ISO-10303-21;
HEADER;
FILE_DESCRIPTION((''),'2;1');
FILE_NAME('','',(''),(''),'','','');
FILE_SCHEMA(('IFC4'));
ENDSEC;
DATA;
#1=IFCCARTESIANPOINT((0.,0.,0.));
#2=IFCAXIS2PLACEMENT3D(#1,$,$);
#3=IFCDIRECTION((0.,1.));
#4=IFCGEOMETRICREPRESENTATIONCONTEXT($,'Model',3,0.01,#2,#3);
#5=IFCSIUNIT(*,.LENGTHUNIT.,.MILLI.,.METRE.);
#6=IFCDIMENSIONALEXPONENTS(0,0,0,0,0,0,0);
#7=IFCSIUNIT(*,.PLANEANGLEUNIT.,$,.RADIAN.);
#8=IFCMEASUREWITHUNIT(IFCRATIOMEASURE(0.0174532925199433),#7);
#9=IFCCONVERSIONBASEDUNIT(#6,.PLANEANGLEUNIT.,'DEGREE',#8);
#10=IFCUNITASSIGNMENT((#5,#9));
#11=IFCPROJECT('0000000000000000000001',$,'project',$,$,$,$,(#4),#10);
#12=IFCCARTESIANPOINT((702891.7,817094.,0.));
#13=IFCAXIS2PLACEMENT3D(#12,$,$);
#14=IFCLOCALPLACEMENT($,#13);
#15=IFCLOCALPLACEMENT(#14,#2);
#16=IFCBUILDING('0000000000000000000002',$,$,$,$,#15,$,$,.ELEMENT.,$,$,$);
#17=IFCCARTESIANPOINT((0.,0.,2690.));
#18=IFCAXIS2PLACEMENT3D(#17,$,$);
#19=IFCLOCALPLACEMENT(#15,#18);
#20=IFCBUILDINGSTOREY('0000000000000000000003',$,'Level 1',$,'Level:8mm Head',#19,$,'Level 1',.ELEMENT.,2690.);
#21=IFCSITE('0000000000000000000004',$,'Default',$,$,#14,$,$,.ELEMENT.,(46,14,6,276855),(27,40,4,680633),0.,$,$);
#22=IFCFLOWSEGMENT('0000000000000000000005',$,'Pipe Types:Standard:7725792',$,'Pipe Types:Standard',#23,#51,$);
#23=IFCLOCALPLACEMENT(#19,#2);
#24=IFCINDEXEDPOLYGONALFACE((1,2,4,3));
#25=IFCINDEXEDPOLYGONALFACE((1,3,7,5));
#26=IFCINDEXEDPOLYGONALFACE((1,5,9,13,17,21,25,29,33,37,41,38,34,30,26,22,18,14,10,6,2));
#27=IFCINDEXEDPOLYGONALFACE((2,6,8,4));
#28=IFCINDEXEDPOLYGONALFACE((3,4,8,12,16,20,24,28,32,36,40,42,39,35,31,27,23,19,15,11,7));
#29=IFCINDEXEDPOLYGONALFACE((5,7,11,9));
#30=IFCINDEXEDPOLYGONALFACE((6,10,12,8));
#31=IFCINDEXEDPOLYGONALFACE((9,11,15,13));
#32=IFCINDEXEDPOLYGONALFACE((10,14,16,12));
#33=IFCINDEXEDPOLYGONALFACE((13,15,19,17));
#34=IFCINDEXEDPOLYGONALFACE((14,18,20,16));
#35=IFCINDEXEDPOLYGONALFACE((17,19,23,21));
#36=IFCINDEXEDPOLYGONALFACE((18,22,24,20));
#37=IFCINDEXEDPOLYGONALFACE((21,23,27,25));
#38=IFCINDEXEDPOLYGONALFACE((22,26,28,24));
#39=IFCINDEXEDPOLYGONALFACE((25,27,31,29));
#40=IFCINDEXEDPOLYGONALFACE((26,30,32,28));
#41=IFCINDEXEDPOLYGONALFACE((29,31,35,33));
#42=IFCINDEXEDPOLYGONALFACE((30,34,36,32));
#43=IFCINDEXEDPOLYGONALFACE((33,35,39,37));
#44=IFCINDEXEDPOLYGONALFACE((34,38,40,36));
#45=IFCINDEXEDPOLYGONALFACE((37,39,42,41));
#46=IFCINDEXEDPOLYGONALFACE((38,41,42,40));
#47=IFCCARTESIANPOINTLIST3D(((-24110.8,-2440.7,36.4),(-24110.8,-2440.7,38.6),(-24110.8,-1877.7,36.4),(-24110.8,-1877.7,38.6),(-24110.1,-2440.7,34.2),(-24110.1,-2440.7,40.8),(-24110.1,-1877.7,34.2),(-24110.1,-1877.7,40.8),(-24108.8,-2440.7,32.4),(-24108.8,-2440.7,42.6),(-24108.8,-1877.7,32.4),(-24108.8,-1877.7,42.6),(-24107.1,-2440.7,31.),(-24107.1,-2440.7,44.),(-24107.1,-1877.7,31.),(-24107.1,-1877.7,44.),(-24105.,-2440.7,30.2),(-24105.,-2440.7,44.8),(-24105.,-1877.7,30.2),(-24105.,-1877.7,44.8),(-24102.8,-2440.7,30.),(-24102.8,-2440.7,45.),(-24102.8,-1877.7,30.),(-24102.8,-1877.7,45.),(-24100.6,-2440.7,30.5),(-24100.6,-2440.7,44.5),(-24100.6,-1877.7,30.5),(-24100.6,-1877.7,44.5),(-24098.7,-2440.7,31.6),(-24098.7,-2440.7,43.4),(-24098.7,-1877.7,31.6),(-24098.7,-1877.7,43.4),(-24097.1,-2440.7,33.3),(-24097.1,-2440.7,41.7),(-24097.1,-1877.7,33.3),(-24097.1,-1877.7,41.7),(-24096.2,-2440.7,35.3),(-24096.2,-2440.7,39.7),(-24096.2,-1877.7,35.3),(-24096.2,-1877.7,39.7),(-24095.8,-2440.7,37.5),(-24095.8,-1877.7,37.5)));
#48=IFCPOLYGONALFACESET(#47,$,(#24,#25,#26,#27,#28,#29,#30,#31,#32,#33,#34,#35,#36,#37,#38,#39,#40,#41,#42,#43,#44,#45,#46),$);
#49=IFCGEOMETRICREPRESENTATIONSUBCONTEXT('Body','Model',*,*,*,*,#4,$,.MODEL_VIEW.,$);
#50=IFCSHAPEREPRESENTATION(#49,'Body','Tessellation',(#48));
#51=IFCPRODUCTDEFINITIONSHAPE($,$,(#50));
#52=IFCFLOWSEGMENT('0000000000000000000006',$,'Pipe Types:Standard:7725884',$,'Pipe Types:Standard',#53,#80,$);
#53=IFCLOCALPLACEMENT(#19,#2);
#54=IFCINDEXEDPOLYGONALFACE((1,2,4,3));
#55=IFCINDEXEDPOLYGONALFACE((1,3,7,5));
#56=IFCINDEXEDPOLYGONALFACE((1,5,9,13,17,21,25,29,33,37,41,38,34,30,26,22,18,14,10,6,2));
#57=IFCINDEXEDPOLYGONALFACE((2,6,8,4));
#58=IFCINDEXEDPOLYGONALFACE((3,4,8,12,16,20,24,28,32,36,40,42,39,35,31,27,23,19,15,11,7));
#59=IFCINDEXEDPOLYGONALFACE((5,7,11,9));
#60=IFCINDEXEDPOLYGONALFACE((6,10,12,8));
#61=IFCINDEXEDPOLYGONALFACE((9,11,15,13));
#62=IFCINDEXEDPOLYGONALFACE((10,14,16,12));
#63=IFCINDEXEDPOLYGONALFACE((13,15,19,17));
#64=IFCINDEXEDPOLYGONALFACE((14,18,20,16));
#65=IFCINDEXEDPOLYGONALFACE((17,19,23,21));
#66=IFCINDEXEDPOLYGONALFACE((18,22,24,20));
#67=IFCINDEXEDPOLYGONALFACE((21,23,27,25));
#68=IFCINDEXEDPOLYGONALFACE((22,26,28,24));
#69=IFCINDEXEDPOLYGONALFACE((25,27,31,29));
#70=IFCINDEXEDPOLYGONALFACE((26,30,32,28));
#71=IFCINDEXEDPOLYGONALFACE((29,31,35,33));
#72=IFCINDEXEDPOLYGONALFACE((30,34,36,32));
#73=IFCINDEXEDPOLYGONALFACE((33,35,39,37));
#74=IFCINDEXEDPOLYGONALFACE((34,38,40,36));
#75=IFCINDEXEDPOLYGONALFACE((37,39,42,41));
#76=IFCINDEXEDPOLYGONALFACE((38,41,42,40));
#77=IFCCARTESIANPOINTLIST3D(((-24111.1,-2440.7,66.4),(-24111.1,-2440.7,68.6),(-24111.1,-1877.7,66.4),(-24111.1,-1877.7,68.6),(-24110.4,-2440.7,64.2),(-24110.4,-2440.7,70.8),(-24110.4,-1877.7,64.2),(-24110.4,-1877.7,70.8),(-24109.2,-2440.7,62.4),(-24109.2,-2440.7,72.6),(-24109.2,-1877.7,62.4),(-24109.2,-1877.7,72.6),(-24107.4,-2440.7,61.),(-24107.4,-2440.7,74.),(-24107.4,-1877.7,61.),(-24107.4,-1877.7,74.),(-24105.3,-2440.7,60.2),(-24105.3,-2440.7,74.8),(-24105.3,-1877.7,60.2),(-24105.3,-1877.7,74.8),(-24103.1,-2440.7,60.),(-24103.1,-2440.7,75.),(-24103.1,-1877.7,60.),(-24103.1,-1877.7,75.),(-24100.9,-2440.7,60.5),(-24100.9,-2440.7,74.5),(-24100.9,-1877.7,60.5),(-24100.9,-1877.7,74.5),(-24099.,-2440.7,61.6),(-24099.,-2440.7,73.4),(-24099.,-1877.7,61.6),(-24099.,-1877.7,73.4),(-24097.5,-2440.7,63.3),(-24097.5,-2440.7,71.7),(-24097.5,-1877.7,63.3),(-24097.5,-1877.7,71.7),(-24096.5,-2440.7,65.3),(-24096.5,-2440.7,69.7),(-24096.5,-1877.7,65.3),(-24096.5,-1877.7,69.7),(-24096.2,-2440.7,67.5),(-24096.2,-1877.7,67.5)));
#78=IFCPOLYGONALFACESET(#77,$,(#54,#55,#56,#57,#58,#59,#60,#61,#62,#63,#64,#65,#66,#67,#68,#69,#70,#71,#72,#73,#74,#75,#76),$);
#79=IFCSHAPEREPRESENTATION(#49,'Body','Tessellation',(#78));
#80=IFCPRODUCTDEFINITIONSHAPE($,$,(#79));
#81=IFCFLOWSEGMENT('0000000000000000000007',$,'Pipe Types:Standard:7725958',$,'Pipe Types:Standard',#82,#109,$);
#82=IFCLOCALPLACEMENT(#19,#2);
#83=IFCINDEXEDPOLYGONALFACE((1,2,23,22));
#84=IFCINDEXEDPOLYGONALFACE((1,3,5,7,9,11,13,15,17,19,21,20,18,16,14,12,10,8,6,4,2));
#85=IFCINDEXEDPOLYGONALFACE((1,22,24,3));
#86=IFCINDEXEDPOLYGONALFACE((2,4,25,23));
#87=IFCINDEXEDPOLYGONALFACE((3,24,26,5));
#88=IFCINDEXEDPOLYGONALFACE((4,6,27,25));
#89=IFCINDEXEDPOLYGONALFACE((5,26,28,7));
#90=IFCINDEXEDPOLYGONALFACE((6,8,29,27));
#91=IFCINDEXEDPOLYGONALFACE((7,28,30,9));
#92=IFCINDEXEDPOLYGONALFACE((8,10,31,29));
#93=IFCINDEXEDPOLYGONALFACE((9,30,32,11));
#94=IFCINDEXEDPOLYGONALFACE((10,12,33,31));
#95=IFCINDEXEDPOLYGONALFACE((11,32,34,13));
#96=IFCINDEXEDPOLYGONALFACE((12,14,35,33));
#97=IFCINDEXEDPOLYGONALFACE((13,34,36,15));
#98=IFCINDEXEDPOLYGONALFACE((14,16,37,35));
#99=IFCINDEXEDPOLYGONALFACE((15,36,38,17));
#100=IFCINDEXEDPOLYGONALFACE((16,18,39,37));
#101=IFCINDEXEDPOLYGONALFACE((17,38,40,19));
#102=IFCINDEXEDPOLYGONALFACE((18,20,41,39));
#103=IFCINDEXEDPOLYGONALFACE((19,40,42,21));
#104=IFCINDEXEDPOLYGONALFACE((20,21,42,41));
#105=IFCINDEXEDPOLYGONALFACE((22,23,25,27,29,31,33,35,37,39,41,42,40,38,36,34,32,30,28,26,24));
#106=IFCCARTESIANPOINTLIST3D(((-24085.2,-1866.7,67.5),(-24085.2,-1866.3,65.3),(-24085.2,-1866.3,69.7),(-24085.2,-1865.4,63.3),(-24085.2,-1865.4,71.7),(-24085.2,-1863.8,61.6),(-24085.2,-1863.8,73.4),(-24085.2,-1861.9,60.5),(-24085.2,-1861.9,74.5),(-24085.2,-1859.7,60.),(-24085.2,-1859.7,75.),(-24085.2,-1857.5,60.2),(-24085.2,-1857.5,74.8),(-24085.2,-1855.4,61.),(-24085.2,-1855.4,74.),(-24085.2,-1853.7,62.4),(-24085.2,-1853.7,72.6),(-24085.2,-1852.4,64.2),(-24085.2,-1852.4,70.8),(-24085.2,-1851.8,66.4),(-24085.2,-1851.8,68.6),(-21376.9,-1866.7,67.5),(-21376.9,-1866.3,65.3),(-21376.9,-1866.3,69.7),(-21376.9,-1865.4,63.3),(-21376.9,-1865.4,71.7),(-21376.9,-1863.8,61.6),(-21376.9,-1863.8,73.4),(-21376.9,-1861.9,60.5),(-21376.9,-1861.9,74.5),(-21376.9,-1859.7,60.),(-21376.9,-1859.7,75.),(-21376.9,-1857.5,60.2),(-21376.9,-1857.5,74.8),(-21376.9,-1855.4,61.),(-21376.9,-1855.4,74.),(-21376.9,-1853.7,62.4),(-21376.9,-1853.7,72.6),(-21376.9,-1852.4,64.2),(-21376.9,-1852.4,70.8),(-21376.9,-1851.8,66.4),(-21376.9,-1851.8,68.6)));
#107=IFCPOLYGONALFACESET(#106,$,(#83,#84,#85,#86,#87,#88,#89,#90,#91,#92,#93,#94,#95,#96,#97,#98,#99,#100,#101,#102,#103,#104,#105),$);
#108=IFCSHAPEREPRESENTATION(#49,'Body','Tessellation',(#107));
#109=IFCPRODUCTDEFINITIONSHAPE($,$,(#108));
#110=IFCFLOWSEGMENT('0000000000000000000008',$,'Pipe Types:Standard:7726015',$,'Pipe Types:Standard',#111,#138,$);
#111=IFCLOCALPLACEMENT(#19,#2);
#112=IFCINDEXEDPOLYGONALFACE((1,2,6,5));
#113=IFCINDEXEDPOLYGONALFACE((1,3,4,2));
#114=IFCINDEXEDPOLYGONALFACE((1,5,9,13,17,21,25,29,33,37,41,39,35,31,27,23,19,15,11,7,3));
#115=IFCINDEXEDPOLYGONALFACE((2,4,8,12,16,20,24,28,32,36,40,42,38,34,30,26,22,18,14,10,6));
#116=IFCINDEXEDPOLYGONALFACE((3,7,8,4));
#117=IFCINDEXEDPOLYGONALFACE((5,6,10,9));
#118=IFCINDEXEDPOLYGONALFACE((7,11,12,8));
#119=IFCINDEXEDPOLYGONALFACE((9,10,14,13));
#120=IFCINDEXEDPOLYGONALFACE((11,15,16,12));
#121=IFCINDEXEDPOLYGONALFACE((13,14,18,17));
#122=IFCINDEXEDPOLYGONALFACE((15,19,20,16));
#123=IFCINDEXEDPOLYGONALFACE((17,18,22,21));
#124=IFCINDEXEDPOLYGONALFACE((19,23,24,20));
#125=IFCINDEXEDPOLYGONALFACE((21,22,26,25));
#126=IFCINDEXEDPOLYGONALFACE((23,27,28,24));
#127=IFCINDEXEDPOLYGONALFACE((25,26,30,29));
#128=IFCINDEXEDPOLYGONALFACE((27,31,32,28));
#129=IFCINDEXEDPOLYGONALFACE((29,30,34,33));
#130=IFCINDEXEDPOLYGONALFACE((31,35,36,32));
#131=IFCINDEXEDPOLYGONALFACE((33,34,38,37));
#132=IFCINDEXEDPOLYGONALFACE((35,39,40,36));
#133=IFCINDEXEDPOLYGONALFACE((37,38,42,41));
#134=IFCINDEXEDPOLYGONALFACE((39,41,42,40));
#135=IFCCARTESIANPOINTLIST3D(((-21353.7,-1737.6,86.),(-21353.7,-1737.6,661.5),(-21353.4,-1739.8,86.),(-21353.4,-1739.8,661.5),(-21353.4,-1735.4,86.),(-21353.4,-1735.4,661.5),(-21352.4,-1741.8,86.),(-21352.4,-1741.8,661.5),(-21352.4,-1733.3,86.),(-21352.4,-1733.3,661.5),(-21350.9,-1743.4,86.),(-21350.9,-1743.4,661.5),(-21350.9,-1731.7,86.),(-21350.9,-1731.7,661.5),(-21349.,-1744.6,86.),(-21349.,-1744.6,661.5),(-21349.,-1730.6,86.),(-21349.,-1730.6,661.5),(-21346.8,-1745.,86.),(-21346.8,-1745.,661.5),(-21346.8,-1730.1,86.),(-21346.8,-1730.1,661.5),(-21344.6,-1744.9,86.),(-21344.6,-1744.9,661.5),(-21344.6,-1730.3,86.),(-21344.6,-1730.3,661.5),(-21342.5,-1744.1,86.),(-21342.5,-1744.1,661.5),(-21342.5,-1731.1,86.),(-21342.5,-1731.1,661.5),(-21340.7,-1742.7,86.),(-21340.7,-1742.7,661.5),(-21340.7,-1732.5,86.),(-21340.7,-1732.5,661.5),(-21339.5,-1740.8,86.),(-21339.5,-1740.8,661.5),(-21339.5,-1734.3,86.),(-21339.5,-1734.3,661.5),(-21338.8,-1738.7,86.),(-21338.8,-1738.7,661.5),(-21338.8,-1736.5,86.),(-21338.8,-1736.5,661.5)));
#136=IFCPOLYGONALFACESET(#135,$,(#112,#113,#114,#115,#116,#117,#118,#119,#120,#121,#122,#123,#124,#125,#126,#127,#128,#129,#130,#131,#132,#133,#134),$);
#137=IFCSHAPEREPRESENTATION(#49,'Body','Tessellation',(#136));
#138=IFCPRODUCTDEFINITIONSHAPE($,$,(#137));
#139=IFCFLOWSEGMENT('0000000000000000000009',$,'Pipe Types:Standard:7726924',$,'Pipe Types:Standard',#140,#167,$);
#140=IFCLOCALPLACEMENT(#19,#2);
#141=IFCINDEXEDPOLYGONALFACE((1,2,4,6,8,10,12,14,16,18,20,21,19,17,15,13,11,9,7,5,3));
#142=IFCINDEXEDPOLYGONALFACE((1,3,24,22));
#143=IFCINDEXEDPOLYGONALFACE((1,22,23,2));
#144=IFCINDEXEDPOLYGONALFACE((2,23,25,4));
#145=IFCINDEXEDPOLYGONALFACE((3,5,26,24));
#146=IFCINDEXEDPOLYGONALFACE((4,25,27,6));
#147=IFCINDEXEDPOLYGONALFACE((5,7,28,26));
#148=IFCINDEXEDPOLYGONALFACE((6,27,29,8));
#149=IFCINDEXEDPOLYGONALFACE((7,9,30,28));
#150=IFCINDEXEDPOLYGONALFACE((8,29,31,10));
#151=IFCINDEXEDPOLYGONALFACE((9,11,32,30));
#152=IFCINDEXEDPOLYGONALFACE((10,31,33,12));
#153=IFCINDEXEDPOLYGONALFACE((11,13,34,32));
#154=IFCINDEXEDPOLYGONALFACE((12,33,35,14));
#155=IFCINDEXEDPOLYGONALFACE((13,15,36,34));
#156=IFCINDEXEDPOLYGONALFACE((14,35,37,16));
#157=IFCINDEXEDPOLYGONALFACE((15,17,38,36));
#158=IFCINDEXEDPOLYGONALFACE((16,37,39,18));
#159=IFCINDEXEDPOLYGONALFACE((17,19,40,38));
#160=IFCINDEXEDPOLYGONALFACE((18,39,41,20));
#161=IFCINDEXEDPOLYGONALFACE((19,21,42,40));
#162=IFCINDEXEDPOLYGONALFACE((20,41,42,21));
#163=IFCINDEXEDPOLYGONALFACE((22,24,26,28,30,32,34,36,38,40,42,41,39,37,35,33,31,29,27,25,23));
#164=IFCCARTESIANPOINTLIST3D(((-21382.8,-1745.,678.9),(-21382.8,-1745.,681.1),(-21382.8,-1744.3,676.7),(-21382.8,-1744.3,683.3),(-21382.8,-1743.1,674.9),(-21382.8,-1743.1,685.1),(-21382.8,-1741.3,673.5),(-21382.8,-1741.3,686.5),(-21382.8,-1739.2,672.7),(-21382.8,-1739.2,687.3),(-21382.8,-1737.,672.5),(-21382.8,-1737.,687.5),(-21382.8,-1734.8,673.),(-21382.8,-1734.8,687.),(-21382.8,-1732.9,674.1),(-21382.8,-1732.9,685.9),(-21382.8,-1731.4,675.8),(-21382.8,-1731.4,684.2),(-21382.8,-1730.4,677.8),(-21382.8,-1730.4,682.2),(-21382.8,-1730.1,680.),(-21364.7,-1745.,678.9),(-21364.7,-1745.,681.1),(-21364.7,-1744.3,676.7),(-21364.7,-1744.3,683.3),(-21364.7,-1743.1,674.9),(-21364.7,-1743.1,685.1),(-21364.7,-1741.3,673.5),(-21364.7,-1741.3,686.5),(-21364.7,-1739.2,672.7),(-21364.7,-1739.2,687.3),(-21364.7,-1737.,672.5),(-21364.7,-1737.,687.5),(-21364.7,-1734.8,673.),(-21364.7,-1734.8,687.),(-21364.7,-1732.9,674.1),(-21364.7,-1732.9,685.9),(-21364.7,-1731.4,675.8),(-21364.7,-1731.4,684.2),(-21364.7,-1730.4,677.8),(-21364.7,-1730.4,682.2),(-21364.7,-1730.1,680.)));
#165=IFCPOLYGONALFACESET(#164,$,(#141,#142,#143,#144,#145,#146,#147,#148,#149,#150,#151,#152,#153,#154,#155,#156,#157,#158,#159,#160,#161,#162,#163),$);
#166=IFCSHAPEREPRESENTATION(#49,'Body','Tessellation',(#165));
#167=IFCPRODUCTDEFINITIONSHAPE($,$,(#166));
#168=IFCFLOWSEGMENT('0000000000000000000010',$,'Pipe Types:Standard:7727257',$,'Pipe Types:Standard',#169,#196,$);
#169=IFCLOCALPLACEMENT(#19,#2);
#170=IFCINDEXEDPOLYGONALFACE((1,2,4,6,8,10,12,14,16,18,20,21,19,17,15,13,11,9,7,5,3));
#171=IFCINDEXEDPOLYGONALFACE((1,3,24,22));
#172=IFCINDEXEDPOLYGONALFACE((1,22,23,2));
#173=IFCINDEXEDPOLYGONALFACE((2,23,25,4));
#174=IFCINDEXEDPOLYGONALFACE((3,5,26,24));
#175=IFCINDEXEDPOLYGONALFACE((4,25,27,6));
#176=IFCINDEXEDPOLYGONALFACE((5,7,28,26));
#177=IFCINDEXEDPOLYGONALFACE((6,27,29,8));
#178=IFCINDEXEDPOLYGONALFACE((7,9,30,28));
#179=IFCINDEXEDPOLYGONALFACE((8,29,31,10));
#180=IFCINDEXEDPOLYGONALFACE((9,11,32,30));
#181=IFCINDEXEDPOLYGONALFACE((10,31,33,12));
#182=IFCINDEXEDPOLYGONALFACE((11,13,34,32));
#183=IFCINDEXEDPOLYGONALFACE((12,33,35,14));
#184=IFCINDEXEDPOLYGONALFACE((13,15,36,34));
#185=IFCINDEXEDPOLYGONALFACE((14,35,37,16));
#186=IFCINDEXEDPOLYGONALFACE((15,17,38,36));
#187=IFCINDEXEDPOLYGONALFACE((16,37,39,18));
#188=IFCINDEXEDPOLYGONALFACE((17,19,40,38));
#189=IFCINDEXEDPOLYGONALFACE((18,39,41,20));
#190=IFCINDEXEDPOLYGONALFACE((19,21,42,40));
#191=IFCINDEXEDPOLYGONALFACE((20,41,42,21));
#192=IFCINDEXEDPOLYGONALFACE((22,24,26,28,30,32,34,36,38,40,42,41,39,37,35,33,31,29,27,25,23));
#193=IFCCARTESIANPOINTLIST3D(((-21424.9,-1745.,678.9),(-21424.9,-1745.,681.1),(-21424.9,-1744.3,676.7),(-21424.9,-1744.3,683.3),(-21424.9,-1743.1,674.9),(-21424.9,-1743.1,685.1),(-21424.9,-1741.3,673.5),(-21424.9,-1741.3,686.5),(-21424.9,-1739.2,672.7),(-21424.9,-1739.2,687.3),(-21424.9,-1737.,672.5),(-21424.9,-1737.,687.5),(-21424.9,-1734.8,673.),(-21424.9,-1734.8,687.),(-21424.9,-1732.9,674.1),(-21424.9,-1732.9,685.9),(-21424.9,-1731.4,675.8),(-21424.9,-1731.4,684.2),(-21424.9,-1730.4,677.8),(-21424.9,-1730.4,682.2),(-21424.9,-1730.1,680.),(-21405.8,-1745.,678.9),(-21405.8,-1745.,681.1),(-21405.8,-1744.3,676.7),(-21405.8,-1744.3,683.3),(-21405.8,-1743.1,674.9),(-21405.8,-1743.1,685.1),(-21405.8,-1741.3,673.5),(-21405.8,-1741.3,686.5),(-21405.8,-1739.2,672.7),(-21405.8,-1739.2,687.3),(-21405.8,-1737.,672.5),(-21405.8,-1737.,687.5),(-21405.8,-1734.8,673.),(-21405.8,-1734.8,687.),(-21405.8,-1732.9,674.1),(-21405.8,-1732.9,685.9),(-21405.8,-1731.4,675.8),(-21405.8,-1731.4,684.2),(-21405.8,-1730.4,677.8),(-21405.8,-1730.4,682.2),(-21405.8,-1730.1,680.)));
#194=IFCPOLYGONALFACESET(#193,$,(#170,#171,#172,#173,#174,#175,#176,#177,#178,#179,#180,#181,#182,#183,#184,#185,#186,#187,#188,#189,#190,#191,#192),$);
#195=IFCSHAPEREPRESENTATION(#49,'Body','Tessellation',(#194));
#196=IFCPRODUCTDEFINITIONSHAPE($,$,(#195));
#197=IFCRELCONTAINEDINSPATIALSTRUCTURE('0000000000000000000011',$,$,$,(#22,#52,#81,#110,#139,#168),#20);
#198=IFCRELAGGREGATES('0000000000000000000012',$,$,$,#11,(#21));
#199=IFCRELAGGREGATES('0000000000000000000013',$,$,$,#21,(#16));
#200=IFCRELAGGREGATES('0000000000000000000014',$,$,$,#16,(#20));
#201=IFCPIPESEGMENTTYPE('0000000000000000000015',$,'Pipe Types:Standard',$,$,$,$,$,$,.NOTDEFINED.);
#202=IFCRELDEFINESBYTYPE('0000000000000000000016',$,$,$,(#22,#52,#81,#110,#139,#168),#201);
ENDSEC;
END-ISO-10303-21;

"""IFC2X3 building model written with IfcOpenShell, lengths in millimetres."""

from ifc_helpers import new_model, entity, si_unit, converted_unit, direction, frame, frame_2d, origin, origin_2d_with_axis, place, context, subcontext, project, spatial, circle, extrude, type_object, element, save


model = new_model("IFC2X3")

# Units and contexts
model_context = context("Model", 3, precision=0.01, world=origin(), true_north=direction((0.0, 1.0)))
body_context = subcontext(model_context, "Body", "Model", "MODEL_VIEW")
ifc_project = project(units=[si_unit("LENGTHUNIT", "METRE", prefix="MILLI"), converted_unit("PLANEANGLEUNIT", "DEGREE", entity("IfcRatioMeasure", 0.0174532925199433), si_unit("PLANEANGLEUNIT", "RADIAN"), dimensions=[0, 0, 0, 0, 0, 0, 0])], contexts=[model_context])

# Site, building, storey
site_placement = place(None, frame((702891.7, 817094.0, 0.0)))
site = spatial("IfcSite", under=ifc_project, at=site_placement, Name="Default", CompositionType="ELEMENT", RefLatitude=(46, 14, 6, 276855), RefLongitude=(27, 40, 4, 680633), RefElevation=0.0)
building_placement = place(site_placement, origin())
building = spatial("IfcBuilding", under=site, at=building_placement, CompositionType="ELEMENT")
storey_placement = place(building_placement, frame((0.0, 0.0, 2690.0)))
storey = spatial("IfcBuildingStorey", under=building, at=storey_placement, Name="Level 1", ObjectType="Level:8mm Head", LongName="Level 1", CompositionType="ELEMENT", Elevation=2690.0)

# Flow segments
pipe_segment_type = type_object("IfcPipeSegmentType", Name="Pipe Types:Standard", PredefinedType="NOTDEFINED")
flow_segment_1_placement = place(storey_placement, origin())
element("IfcFlowSegment", 1, at=flow_segment_1_placement, inside=storey, type_object=pipe_segment_type, Name="Pipe Types:Standard:7725792", ObjectType="Pipe Types:Standard", context=body_context, shape_type="SweptSolid", body=[
    extrude(circle(Radius=7.5, at=origin_2d_with_axis()), frame((-24103.3, -2440.7, 37.5), z_axis=(0.0, 1.0, 0.0), x_axis=(1.0, 0.0, 0.0)), (0.0, 0.0, 1.0), 563.0),
])
flow_segment_2_placement = place(storey_placement, origin())
element("IfcFlowSegment", 2, at=flow_segment_2_placement, inside=storey, type_object=pipe_segment_type, Name="Pipe Types:Standard:7725884", ObjectType="Pipe Types:Standard", context=body_context, shape_type="SweptSolid", body=[
    extrude(circle(Radius=7.5, at=frame_2d((0.0, 0.0), x_axis=(1.0, 0.0))), frame((-24103.7, -2440.7, 67.5), z_axis=(0.0, 1.0, 0.0), x_axis=(1.0, 0.0, 0.0)), (0.0, 0.0, 1.0), 563.0),
])
flow_segment_3_placement = place(storey_placement, origin())
element("IfcFlowSegment", 3, at=flow_segment_3_placement, inside=storey, type_object=pipe_segment_type, Name="Pipe Types:Standard:7725958", ObjectType="Pipe Types:Standard", context=body_context, shape_type="SweptSolid", body=[
    extrude(circle(Radius=7.5, at=origin_2d_with_axis()), frame((-24085.2, -1859.2, 67.5), z_axis=(1.0, 0.0, 0.0), x_axis=(0.0, -1.0, 0.0)), (0.0, 0.0, 1.0), 2708.2),
])
flow_segment_4_placement = place(storey_placement, origin())
element("IfcFlowSegment", 4, at=flow_segment_4_placement, inside=storey, type_object=pipe_segment_type, Name="Pipe Types:Standard:7726015", ObjectType="Pipe Types:Standard", context=body_context, shape_type="SweptSolid", body=[
    extrude(circle(Radius=7.5, at=origin_2d_with_axis()), frame((-21346.2, -1737.6, 86.0), z_axis=(0.0, 0.0, 1.0), x_axis=(-1.0, 0.0, 0.0)), (0.0, 0.0, 1.0), 575.5),
])
flow_segment_5_placement = place(storey_placement, origin())
element("IfcFlowSegment", 5, at=flow_segment_5_placement, inside=storey, type_object=pipe_segment_type, Name="Pipe Types:Standard:7726924", ObjectType="Pipe Types:Standard", context=body_context, shape_type="SweptSolid", body=[
    extrude(circle(Radius=7.5, at=origin_2d_with_axis()), frame((-21382.8, -1737.6, 680.0), z_axis=(1.0, 0.0, 0.0), x_axis=(0.0, 1.0, 0.0)), (0.0, 0.0, 1.0), 18.1),
])
flow_segment_6_placement = place(storey_placement, origin())
element("IfcFlowSegment", 6, at=flow_segment_6_placement, inside=storey, type_object=pipe_segment_type, Name="Pipe Types:Standard:7727257", ObjectType="Pipe Types:Standard", context=body_context, shape_type="SweptSolid", body=[
    extrude(circle(Radius=7.5, at=frame_2d((0.0, 0.0), x_axis=(1.0, 0.0))), frame((-21424.9, -1737.6, 680.0), z_axis=(1.0, 0.0, 0.0), x_axis=(0.0, 1.0, 0.0)), (0.0, 0.0, 1.0), 19.1),
])

save(model, "model.ifc")
